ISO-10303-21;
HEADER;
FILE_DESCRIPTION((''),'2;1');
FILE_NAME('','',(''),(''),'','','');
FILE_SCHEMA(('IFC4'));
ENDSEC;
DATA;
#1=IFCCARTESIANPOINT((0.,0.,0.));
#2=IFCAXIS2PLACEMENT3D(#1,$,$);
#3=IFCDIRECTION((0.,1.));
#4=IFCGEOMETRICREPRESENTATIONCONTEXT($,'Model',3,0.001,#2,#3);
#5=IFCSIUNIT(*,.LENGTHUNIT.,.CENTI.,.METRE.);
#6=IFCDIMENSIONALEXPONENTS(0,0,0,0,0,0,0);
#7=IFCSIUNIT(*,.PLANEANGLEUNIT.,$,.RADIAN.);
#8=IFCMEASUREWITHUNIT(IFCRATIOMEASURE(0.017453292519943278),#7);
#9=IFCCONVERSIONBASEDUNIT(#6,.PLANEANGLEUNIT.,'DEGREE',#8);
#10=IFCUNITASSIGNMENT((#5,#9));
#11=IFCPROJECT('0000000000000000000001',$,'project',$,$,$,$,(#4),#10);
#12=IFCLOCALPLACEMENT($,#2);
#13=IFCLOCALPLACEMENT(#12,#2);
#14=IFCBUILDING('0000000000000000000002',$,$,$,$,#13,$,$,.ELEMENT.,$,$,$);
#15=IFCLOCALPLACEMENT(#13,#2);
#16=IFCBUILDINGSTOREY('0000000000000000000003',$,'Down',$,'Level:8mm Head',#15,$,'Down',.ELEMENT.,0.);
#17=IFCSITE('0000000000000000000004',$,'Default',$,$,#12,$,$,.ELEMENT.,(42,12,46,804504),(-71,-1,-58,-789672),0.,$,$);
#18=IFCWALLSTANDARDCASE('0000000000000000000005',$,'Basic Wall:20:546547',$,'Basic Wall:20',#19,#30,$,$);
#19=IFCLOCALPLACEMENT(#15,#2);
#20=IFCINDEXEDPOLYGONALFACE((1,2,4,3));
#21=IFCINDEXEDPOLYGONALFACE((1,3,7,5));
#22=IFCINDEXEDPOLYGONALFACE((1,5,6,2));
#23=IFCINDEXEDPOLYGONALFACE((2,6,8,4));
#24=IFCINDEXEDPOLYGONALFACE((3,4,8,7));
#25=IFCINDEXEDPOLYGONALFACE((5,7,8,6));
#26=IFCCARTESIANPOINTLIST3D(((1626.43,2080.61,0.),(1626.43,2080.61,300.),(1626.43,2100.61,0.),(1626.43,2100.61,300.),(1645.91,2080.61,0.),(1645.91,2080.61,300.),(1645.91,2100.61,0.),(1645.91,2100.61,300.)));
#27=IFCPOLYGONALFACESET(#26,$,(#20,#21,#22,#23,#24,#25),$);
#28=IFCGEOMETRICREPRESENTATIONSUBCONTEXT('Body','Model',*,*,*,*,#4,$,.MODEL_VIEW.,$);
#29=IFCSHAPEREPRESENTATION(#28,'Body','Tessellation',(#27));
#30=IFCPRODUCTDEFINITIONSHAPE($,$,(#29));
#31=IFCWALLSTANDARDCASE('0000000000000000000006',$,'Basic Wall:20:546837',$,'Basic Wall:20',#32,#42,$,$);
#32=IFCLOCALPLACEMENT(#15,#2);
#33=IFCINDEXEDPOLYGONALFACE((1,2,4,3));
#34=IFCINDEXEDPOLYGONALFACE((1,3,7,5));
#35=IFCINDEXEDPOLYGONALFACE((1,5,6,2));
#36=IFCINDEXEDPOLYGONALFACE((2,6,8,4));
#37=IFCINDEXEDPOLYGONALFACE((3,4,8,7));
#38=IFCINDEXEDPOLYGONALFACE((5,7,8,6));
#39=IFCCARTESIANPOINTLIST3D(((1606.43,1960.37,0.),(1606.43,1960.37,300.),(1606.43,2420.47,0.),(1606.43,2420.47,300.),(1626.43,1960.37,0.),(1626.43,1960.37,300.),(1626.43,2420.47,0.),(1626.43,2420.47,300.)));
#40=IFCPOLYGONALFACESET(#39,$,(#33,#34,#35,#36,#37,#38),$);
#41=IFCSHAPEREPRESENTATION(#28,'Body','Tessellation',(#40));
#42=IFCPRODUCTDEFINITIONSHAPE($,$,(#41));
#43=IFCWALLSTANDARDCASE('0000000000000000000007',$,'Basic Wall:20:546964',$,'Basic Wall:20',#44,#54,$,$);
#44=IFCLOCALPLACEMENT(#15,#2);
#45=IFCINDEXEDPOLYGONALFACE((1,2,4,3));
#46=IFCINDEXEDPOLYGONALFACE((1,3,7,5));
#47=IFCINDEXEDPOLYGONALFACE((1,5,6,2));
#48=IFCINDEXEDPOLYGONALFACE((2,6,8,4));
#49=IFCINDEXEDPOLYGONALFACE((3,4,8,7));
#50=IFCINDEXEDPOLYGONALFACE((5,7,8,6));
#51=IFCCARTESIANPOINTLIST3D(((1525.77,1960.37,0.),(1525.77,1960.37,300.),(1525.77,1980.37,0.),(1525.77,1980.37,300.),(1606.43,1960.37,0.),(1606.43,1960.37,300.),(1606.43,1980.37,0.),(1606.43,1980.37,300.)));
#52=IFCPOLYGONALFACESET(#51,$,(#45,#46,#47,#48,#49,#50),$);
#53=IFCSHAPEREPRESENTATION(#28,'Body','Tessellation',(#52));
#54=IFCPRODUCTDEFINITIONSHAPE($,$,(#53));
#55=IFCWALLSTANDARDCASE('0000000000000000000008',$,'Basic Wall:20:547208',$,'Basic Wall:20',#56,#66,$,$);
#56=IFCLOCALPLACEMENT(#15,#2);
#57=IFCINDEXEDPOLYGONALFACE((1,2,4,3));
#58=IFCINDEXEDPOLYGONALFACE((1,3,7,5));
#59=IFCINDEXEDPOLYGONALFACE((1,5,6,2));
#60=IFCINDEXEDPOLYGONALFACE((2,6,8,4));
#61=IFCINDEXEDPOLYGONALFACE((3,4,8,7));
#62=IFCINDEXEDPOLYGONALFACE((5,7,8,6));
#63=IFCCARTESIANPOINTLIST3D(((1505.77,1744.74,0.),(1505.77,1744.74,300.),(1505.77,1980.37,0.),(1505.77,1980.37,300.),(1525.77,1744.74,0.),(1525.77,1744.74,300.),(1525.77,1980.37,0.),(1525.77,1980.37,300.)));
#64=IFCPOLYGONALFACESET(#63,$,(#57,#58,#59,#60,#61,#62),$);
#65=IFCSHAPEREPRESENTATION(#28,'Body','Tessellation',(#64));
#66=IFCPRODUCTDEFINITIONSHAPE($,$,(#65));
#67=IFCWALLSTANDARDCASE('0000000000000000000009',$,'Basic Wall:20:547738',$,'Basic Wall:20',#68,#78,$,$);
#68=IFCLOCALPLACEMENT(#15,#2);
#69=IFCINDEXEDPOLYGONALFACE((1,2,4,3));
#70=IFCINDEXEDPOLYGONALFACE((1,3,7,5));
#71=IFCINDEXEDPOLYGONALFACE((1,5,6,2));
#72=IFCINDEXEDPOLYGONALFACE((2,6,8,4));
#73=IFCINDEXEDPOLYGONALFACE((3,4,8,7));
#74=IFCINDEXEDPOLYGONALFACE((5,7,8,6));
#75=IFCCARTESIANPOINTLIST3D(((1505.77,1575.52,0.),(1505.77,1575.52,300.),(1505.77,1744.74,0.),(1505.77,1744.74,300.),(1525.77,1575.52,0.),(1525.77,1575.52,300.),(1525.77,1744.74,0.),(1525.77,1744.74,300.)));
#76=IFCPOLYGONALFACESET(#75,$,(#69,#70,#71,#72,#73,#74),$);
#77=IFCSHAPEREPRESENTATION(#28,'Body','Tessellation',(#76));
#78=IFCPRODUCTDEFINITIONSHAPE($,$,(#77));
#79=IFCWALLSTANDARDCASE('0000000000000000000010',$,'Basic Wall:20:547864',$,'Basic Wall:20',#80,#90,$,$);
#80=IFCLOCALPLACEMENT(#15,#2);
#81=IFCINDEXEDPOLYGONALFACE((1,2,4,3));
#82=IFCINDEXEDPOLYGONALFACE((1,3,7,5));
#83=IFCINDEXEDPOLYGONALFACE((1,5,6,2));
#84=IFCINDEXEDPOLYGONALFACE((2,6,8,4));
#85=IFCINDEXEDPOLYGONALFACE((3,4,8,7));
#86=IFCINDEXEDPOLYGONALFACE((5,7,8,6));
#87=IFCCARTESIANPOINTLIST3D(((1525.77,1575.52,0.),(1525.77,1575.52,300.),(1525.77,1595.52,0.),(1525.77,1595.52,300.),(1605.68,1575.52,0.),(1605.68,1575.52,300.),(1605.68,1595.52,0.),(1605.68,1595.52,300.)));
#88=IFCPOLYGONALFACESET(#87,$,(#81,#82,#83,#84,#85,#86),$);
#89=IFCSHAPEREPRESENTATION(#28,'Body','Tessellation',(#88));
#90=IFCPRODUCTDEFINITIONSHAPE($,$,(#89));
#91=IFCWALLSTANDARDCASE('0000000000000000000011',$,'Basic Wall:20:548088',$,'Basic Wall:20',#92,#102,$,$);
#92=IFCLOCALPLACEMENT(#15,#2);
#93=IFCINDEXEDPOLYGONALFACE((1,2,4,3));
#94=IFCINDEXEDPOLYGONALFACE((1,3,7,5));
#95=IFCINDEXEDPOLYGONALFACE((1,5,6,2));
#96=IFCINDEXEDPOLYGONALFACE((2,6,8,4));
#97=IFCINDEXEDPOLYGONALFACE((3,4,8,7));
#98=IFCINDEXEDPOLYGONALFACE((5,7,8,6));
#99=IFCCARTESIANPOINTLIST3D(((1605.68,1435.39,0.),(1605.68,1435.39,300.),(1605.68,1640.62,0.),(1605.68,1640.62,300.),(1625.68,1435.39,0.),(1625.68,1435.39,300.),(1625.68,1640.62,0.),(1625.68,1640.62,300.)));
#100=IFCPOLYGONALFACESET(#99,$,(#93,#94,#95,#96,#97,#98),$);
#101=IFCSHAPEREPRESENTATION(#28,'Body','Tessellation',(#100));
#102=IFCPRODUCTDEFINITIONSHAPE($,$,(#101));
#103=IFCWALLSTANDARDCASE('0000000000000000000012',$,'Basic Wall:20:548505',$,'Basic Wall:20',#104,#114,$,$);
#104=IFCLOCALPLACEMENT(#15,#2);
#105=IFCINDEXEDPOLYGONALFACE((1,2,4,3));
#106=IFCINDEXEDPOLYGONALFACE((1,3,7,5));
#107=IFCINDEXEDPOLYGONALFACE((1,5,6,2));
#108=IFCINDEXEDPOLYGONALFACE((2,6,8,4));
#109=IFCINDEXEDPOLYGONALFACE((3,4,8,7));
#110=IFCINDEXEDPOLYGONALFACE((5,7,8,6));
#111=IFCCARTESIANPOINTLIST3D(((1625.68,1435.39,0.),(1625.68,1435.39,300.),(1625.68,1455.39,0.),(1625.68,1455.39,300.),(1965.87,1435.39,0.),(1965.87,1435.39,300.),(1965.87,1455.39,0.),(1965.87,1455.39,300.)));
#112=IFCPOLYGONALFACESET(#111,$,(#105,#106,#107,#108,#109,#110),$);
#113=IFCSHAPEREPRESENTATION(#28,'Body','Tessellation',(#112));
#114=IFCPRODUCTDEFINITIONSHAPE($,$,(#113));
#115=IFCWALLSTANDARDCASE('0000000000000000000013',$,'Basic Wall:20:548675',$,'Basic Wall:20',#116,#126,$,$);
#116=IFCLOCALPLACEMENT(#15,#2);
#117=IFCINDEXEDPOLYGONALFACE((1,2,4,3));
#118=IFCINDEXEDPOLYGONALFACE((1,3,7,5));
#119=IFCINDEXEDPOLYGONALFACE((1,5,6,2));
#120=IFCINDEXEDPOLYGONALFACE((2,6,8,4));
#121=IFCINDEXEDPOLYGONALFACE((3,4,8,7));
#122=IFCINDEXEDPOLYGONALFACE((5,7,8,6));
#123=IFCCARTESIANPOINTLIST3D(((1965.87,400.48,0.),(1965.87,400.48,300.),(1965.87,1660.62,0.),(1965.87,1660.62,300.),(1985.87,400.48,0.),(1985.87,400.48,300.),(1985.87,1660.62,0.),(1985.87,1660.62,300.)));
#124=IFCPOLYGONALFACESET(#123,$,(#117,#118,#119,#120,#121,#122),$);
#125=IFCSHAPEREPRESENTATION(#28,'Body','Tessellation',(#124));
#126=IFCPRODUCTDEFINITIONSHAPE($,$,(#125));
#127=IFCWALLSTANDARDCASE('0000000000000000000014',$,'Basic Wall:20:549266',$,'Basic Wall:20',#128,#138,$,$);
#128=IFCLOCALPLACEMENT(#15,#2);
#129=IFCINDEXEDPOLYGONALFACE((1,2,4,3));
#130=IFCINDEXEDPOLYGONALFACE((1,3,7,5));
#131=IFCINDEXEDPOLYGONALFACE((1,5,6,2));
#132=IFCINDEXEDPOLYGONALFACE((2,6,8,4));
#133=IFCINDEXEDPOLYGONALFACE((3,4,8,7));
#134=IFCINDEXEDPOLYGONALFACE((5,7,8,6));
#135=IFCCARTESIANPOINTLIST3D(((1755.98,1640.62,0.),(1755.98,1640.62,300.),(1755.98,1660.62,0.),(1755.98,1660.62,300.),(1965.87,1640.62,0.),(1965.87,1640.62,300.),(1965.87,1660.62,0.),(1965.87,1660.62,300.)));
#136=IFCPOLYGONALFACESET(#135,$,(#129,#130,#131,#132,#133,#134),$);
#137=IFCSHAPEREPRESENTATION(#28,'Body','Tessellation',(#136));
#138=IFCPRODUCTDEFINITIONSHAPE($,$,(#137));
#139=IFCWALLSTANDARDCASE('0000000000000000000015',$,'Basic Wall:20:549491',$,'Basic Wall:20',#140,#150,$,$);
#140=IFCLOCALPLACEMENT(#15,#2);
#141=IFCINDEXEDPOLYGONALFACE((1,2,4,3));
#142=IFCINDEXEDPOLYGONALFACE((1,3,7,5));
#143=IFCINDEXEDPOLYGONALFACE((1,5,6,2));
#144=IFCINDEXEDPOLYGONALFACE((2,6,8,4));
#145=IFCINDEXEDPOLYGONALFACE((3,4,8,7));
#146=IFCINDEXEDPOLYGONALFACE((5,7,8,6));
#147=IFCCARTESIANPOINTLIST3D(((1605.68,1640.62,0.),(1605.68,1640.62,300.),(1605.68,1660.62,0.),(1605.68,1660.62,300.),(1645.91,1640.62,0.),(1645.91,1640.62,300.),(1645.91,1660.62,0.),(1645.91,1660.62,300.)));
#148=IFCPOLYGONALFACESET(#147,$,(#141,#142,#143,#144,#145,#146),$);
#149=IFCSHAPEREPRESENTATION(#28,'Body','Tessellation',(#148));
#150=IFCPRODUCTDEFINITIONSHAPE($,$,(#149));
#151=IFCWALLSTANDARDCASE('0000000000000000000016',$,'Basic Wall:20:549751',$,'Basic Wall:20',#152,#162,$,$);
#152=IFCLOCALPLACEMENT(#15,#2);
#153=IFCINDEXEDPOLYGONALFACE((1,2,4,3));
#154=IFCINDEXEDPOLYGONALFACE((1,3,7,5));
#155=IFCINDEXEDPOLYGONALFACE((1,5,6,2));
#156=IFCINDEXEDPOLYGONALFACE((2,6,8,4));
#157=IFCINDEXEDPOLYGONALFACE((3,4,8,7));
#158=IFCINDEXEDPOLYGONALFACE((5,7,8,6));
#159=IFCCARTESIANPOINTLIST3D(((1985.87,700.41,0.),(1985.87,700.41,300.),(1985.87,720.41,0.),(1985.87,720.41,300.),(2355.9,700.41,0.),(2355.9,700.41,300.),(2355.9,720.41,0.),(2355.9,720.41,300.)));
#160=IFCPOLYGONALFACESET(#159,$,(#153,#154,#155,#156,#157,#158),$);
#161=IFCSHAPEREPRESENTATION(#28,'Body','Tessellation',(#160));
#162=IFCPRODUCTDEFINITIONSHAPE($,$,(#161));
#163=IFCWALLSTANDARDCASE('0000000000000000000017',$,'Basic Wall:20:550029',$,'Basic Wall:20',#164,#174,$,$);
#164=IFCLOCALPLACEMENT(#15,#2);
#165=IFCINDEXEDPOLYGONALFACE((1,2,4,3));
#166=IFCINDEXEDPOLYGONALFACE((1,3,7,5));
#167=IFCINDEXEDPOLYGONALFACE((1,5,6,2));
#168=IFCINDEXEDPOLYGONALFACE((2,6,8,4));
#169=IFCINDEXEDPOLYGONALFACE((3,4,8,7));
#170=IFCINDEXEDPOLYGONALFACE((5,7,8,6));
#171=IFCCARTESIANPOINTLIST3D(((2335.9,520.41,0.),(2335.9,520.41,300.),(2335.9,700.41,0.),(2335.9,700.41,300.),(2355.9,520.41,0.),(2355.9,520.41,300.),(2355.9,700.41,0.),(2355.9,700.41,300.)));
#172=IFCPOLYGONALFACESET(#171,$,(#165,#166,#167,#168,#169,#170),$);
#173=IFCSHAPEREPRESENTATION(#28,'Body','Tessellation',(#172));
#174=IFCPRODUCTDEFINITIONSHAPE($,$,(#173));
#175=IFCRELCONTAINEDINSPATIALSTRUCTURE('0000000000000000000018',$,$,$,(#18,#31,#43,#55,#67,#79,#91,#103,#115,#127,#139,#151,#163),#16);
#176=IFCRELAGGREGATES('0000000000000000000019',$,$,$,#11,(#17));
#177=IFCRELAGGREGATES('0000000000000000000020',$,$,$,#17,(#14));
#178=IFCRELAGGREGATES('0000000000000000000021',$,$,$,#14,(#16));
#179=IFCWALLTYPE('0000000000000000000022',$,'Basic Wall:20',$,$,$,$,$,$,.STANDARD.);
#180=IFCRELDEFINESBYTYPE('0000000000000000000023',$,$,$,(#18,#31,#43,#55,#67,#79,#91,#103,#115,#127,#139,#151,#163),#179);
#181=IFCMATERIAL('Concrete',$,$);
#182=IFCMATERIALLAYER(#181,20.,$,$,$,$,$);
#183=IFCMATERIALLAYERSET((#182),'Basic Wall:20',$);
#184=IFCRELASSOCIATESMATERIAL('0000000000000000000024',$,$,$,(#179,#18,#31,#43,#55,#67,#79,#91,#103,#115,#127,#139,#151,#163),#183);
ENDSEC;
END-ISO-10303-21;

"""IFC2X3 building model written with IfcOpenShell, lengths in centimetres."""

from ifc_helpers import new_model, entity, si_unit, converted_unit, direction, frame, frame_2d, origin, place, context, subcontext, project, spatial, rectangle, extrude, material, layer, layer_set, layer_usage, type_object, element, save


model = new_model("IFC2X3")

# Units and contexts
model_context = context("Model", 3, precision=0.001, world=origin(), true_north=direction((0.0, 1.0)))
body_context = subcontext(model_context, "Body", "Model", "MODEL_VIEW")
ifc_project = project(units=[si_unit("LENGTHUNIT", "METRE", prefix="CENTI"), converted_unit("PLANEANGLEUNIT", "DEGREE", entity("IfcRatioMeasure", 0.017453292519943278), si_unit("PLANEANGLEUNIT", "RADIAN"), dimensions=[0, 0, 0, 0, 0, 0, 0])], contexts=[model_context])

# Site, building, storey
site_placement = place(None, origin())
site = spatial("IfcSite", under=ifc_project, at=site_placement, Name="Default", CompositionType="ELEMENT", RefLatitude=(42, 12, 46, 804504), RefLongitude=(-71, -1, -58, -789672), RefElevation=0.0)
building_placement = place(site_placement, origin())
building = spatial("IfcBuilding", under=site, at=building_placement, CompositionType="ELEMENT")
storey_placement = place(building_placement, origin())
storey = spatial("IfcBuildingStorey", under=building, at=storey_placement, Name="Down", ObjectType="Level:8mm Head", LongName="Down", CompositionType="ELEMENT", Elevation=0.0)

# Shared definitions
ifc_material = material(Name="Concrete")

# Walls
ifc_layer_1 = layer(ifc_material, 20.0)
ifc_layer_set_1 = layer_set([ifc_layer_1], Name="Basic Wall:20")
wall_type_1 = type_object("IfcWallType", Name="Basic Wall:20", PredefinedType="STANDARD", material=ifc_layer_set_1)
ifc_layer_usage_1 = layer_usage(ifc_layer_set_1, "AXIS2", "NEGATIVE", 10.0)
wall_1_placement = place(storey_placement, frame((1645.91, 2090.61, 0.0), z_axis=(0.0, 0.0, 1.0), x_axis=(-1.0, 0.0, 0.0)))
element("IfcWallStandardCase", 1, at=wall_1_placement, inside=storey, type_object=wall_type_1, material=ifc_layer_usage_1, Name="Basic Wall:20:546547", ObjectType="Basic Wall:20", context=body_context, shape_type="SweptSolid", body=[
    extrude(rectangle(XDim=19.48, YDim=20.0, at=frame_2d((9.74, 0.0), x_axis=(-1.0, 0.0))), origin(), (0.0, 0.0, 1.0), 300.0),
])
ifc_layer_usage_2 = layer_usage(ifc_layer_set_1, "AXIS2", "POSITIVE", -10.0)
wall_2_placement = place(storey_placement, frame((1616.43, 2420.47, 0.0), z_axis=(0.0, 0.0, 1.0), x_axis=(0.0, -1.0, 0.0)))
element("IfcWallStandardCase", 2, at=wall_2_placement, inside=storey, type_object=wall_type_1, material=ifc_layer_usage_2, Name="Basic Wall:20:546837", ObjectType="Basic Wall:20", context=body_context, shape_type="SweptSolid", body=[
    extrude(rectangle(XDim=460.1, YDim=20.0, at=frame_2d((230.05, 0.0), x_axis=(-1.0, 0.0))), origin(), (0.0, 0.0, 1.0), 300.0),
])
ifc_layer_usage_3 = layer_usage(ifc_layer_set_1, "AXIS2", "NEGATIVE", 10.0)
wall_3_placement = place(storey_placement, frame((1606.43, 1970.37, 0.0), z_axis=(0.0, 0.0, 1.0), x_axis=(-1.0, 0.0, 0.0)))
element("IfcWallStandardCase", 3, at=wall_3_placement, inside=storey, type_object=wall_type_1, material=ifc_layer_usage_3, Name="Basic Wall:20:546964", ObjectType="Basic Wall:20", context=body_context, shape_type="SweptSolid", body=[
    extrude(rectangle(XDim=80.66, YDim=20.0, at=frame_2d((40.33, 0.0), x_axis=(-1.0, 0.0))), origin(), (0.0, 0.0, 1.0), 300.0),
])
ifc_layer_usage_4 = layer_usage(ifc_layer_set_1, "AXIS2", "POSITIVE", -10.0)
wall_4_placement = place(storey_placement, frame((1515.77, 1980.37, 0.0), z_axis=(0.0, 0.0, 1.0), x_axis=(0.0, -1.0, 0.0)))
element("IfcWallStandardCase", 4, at=wall_4_placement, inside=storey, type_object=wall_type_1, material=ifc_layer_usage_4, Name="Basic Wall:20:547208", ObjectType="Basic Wall:20", context=body_context, shape_type="SweptSolid", body=[
    extrude(rectangle(XDim=235.63, YDim=20.0, at=frame_2d((117.81, 0.0), x_axis=(-1.0, 0.0))), origin(), (0.0, 0.0, 1.0), 300.0),
])
ifc_layer_usage_5 = layer_usage(ifc_layer_set_1, "AXIS2", "NEGATIVE", 10.0)
wall_5_placement = place(storey_placement, frame((1515.77, 1575.52, 0.0), z_axis=(0.0, 0.0, 1.0), x_axis=(0.0, 1.0, 0.0)))
element("IfcWallStandardCase", 5, at=wall_5_placement, inside=storey, type_object=wall_type_1, material=ifc_layer_usage_5, Name="Basic Wall:20:547738", ObjectType="Basic Wall:20", context=body_context, shape_type="SweptSolid", body=[
    extrude(rectangle(XDim=169.22, YDim=20.0, at=frame_2d((84.61, 0.0), x_axis=(-1.0, 0.0))), origin(), (0.0, 0.0, 1.0), 300.0),
])
ifc_layer_usage_6 = layer_usage(ifc_layer_set_1, "AXIS2", "POSITIVE", -10.0)
wall_6_placement = place(storey_placement, frame((1525.77, 1585.52, 0.0)))
element("IfcWallStandardCase", 6, at=wall_6_placement, inside=storey, type_object=wall_type_1, material=ifc_layer_usage_6, Name="Basic Wall:20:547864", ObjectType="Basic Wall:20", context=body_context, shape_type="SweptSolid", body=[
    extrude(rectangle(XDim=79.92, YDim=20.0, at=frame_2d((39.96, 0.0), x_axis=(-1.0, 0.0))), origin(), (0.0, 0.0, 1.0), 300.0),
])
ifc_layer_usage_7 = layer_usage(ifc_layer_set_1, "AXIS2", "POSITIVE", -10.0)
wall_7_placement = place(storey_placement, frame((1615.68, 1640.62, 0.0), z_axis=(0.0, 0.0, 1.0), x_axis=(0.0, -1.0, 0.0)))
element("IfcWallStandardCase", 7, at=wall_7_placement, inside=storey, type_object=wall_type_1, material=ifc_layer_usage_7, Name="Basic Wall:20:548088", ObjectType="Basic Wall:20", context=body_context, shape_type="SweptSolid", body=[
    extrude(rectangle(XDim=205.23, YDim=20.0, at=frame_2d((102.62, 0.0), x_axis=(-1.0, 0.0))), origin(), (0.0, 0.0, 1.0), 300.0),
])
ifc_layer_usage_8 = layer_usage(ifc_layer_set_1, "AXIS2", "POSITIVE", -10.0)
wall_8_placement = place(storey_placement, frame((1625.68, 1445.39, 0.0)))
element("IfcWallStandardCase", 8, at=wall_8_placement, inside=storey, type_object=wall_type_1, material=ifc_layer_usage_8, Name="Basic Wall:20:548505", ObjectType="Basic Wall:20", context=body_context, shape_type="SweptSolid", body=[
    extrude(rectangle(XDim=340.19, YDim=20.0, at=frame_2d((170.09, 0.0), x_axis=(-1.0, 0.0))), origin(), (0.0, 0.0, 1.0), 300.0),
])
ifc_layer_usage_9 = layer_usage(ifc_layer_set_1, "AXIS2", "NEGATIVE", 10.0)
wall_9_placement = place(storey_placement, frame((1975.87, 1660.62, 0.0), z_axis=(0.0, 0.0, 1.0), x_axis=(0.0, -1.0, 0.0)))
element("IfcWallStandardCase", 9, at=wall_9_placement, inside=storey, type_object=wall_type_1, material=ifc_layer_usage_9, Name="Basic Wall:20:548675", ObjectType="Basic Wall:20", context=body_context, shape_type="SweptSolid", body=[
    extrude(rectangle(XDim=1260.14, YDim=20.0, at=frame_2d((630.07, 0.0), x_axis=(-1.0, 0.0))), origin(), (0.0, 0.0, 1.0), 300.0),
])
ifc_layer_usage_10 = layer_usage(ifc_layer_set_1, "AXIS2", "POSITIVE", -10.0)
wall_10_placement = place(storey_placement, frame((1965.87, 1650.62, 0.0), z_axis=(0.0, 0.0, 1.0), x_axis=(-1.0, 0.0, 0.0)))
element("IfcWallStandardCase", 10, at=wall_10_placement, inside=storey, type_object=wall_type_1, material=ifc_layer_usage_10, Name="Basic Wall:20:549266", ObjectType="Basic Wall:20", context=body_context, shape_type="SweptSolid", body=[
    extrude(rectangle(XDim=209.89, YDim=20.0, at=frame_2d((104.95, 0.0), x_axis=(-1.0, 0.0))), origin(), (0.0, 0.0, 1.0), 300.0),
])
ifc_layer_usage_11 = layer_usage(ifc_layer_set_1, "AXIS2", "POSITIVE", -10.0)
wall_11_placement = place(storey_placement, frame((1645.91, 1650.62, 0.0), z_axis=(0.0, 0.0, 1.0), x_axis=(-1.0, 0.0, 0.0)))
element("IfcWallStandardCase", 11, at=wall_11_placement, inside=storey, type_object=wall_type_1, material=ifc_layer_usage_11, Name="Basic Wall:20:549491", ObjectType="Basic Wall:20", context=body_context, shape_type="SweptSolid", body=[
    extrude(rectangle(XDim=40.22, YDim=20.0, at=frame_2d((20.11, 0.0), x_axis=(-1.0, 0.0))), origin(), (0.0, 0.0, 1.0), 300.0),
])
ifc_layer_usage_12 = layer_usage(ifc_layer_set_1, "AXIS2", "POSITIVE", -10.0)
wall_12_placement = place(storey_placement, frame((1985.87, 710.41, 0.0)))
element("IfcWallStandardCase", 12, at=wall_12_placement, inside=storey, type_object=wall_type_1, material=ifc_layer_usage_12, Name="Basic Wall:20:549751", ObjectType="Basic Wall:20", context=body_context, shape_type="SweptSolid", body=[
    extrude(rectangle(XDim=370.03, YDim=20.0, at=frame_2d((185.01, 0.0), x_axis=(-1.0, 0.0))), origin(), (0.0, 0.0, 1.0), 300.0),
])
ifc_layer_usage_13 = layer_usage(ifc_layer_set_1, "AXIS2", "NEGATIVE", 10.0)
wall_13_placement = place(storey_placement, frame((2345.9, 700.41, 0.0), z_axis=(0.0, 0.0, 1.0), x_axis=(0.0, -1.0, 0.0)))
element("IfcWallStandardCase", 13, at=wall_13_placement, inside=storey, type_object=wall_type_1, material=ifc_layer_usage_13, Name="Basic Wall:20:550029", ObjectType="Basic Wall:20", context=body_context, shape_type="SweptSolid", body=[
    extrude(rectangle(XDim=180.0, YDim=20.0, at=frame_2d((90.0, 0.0), x_axis=(-1.0, 0.0))), origin(), (0.0, 0.0, 1.0), 300.0),
])

save(model, "model.ifc")
